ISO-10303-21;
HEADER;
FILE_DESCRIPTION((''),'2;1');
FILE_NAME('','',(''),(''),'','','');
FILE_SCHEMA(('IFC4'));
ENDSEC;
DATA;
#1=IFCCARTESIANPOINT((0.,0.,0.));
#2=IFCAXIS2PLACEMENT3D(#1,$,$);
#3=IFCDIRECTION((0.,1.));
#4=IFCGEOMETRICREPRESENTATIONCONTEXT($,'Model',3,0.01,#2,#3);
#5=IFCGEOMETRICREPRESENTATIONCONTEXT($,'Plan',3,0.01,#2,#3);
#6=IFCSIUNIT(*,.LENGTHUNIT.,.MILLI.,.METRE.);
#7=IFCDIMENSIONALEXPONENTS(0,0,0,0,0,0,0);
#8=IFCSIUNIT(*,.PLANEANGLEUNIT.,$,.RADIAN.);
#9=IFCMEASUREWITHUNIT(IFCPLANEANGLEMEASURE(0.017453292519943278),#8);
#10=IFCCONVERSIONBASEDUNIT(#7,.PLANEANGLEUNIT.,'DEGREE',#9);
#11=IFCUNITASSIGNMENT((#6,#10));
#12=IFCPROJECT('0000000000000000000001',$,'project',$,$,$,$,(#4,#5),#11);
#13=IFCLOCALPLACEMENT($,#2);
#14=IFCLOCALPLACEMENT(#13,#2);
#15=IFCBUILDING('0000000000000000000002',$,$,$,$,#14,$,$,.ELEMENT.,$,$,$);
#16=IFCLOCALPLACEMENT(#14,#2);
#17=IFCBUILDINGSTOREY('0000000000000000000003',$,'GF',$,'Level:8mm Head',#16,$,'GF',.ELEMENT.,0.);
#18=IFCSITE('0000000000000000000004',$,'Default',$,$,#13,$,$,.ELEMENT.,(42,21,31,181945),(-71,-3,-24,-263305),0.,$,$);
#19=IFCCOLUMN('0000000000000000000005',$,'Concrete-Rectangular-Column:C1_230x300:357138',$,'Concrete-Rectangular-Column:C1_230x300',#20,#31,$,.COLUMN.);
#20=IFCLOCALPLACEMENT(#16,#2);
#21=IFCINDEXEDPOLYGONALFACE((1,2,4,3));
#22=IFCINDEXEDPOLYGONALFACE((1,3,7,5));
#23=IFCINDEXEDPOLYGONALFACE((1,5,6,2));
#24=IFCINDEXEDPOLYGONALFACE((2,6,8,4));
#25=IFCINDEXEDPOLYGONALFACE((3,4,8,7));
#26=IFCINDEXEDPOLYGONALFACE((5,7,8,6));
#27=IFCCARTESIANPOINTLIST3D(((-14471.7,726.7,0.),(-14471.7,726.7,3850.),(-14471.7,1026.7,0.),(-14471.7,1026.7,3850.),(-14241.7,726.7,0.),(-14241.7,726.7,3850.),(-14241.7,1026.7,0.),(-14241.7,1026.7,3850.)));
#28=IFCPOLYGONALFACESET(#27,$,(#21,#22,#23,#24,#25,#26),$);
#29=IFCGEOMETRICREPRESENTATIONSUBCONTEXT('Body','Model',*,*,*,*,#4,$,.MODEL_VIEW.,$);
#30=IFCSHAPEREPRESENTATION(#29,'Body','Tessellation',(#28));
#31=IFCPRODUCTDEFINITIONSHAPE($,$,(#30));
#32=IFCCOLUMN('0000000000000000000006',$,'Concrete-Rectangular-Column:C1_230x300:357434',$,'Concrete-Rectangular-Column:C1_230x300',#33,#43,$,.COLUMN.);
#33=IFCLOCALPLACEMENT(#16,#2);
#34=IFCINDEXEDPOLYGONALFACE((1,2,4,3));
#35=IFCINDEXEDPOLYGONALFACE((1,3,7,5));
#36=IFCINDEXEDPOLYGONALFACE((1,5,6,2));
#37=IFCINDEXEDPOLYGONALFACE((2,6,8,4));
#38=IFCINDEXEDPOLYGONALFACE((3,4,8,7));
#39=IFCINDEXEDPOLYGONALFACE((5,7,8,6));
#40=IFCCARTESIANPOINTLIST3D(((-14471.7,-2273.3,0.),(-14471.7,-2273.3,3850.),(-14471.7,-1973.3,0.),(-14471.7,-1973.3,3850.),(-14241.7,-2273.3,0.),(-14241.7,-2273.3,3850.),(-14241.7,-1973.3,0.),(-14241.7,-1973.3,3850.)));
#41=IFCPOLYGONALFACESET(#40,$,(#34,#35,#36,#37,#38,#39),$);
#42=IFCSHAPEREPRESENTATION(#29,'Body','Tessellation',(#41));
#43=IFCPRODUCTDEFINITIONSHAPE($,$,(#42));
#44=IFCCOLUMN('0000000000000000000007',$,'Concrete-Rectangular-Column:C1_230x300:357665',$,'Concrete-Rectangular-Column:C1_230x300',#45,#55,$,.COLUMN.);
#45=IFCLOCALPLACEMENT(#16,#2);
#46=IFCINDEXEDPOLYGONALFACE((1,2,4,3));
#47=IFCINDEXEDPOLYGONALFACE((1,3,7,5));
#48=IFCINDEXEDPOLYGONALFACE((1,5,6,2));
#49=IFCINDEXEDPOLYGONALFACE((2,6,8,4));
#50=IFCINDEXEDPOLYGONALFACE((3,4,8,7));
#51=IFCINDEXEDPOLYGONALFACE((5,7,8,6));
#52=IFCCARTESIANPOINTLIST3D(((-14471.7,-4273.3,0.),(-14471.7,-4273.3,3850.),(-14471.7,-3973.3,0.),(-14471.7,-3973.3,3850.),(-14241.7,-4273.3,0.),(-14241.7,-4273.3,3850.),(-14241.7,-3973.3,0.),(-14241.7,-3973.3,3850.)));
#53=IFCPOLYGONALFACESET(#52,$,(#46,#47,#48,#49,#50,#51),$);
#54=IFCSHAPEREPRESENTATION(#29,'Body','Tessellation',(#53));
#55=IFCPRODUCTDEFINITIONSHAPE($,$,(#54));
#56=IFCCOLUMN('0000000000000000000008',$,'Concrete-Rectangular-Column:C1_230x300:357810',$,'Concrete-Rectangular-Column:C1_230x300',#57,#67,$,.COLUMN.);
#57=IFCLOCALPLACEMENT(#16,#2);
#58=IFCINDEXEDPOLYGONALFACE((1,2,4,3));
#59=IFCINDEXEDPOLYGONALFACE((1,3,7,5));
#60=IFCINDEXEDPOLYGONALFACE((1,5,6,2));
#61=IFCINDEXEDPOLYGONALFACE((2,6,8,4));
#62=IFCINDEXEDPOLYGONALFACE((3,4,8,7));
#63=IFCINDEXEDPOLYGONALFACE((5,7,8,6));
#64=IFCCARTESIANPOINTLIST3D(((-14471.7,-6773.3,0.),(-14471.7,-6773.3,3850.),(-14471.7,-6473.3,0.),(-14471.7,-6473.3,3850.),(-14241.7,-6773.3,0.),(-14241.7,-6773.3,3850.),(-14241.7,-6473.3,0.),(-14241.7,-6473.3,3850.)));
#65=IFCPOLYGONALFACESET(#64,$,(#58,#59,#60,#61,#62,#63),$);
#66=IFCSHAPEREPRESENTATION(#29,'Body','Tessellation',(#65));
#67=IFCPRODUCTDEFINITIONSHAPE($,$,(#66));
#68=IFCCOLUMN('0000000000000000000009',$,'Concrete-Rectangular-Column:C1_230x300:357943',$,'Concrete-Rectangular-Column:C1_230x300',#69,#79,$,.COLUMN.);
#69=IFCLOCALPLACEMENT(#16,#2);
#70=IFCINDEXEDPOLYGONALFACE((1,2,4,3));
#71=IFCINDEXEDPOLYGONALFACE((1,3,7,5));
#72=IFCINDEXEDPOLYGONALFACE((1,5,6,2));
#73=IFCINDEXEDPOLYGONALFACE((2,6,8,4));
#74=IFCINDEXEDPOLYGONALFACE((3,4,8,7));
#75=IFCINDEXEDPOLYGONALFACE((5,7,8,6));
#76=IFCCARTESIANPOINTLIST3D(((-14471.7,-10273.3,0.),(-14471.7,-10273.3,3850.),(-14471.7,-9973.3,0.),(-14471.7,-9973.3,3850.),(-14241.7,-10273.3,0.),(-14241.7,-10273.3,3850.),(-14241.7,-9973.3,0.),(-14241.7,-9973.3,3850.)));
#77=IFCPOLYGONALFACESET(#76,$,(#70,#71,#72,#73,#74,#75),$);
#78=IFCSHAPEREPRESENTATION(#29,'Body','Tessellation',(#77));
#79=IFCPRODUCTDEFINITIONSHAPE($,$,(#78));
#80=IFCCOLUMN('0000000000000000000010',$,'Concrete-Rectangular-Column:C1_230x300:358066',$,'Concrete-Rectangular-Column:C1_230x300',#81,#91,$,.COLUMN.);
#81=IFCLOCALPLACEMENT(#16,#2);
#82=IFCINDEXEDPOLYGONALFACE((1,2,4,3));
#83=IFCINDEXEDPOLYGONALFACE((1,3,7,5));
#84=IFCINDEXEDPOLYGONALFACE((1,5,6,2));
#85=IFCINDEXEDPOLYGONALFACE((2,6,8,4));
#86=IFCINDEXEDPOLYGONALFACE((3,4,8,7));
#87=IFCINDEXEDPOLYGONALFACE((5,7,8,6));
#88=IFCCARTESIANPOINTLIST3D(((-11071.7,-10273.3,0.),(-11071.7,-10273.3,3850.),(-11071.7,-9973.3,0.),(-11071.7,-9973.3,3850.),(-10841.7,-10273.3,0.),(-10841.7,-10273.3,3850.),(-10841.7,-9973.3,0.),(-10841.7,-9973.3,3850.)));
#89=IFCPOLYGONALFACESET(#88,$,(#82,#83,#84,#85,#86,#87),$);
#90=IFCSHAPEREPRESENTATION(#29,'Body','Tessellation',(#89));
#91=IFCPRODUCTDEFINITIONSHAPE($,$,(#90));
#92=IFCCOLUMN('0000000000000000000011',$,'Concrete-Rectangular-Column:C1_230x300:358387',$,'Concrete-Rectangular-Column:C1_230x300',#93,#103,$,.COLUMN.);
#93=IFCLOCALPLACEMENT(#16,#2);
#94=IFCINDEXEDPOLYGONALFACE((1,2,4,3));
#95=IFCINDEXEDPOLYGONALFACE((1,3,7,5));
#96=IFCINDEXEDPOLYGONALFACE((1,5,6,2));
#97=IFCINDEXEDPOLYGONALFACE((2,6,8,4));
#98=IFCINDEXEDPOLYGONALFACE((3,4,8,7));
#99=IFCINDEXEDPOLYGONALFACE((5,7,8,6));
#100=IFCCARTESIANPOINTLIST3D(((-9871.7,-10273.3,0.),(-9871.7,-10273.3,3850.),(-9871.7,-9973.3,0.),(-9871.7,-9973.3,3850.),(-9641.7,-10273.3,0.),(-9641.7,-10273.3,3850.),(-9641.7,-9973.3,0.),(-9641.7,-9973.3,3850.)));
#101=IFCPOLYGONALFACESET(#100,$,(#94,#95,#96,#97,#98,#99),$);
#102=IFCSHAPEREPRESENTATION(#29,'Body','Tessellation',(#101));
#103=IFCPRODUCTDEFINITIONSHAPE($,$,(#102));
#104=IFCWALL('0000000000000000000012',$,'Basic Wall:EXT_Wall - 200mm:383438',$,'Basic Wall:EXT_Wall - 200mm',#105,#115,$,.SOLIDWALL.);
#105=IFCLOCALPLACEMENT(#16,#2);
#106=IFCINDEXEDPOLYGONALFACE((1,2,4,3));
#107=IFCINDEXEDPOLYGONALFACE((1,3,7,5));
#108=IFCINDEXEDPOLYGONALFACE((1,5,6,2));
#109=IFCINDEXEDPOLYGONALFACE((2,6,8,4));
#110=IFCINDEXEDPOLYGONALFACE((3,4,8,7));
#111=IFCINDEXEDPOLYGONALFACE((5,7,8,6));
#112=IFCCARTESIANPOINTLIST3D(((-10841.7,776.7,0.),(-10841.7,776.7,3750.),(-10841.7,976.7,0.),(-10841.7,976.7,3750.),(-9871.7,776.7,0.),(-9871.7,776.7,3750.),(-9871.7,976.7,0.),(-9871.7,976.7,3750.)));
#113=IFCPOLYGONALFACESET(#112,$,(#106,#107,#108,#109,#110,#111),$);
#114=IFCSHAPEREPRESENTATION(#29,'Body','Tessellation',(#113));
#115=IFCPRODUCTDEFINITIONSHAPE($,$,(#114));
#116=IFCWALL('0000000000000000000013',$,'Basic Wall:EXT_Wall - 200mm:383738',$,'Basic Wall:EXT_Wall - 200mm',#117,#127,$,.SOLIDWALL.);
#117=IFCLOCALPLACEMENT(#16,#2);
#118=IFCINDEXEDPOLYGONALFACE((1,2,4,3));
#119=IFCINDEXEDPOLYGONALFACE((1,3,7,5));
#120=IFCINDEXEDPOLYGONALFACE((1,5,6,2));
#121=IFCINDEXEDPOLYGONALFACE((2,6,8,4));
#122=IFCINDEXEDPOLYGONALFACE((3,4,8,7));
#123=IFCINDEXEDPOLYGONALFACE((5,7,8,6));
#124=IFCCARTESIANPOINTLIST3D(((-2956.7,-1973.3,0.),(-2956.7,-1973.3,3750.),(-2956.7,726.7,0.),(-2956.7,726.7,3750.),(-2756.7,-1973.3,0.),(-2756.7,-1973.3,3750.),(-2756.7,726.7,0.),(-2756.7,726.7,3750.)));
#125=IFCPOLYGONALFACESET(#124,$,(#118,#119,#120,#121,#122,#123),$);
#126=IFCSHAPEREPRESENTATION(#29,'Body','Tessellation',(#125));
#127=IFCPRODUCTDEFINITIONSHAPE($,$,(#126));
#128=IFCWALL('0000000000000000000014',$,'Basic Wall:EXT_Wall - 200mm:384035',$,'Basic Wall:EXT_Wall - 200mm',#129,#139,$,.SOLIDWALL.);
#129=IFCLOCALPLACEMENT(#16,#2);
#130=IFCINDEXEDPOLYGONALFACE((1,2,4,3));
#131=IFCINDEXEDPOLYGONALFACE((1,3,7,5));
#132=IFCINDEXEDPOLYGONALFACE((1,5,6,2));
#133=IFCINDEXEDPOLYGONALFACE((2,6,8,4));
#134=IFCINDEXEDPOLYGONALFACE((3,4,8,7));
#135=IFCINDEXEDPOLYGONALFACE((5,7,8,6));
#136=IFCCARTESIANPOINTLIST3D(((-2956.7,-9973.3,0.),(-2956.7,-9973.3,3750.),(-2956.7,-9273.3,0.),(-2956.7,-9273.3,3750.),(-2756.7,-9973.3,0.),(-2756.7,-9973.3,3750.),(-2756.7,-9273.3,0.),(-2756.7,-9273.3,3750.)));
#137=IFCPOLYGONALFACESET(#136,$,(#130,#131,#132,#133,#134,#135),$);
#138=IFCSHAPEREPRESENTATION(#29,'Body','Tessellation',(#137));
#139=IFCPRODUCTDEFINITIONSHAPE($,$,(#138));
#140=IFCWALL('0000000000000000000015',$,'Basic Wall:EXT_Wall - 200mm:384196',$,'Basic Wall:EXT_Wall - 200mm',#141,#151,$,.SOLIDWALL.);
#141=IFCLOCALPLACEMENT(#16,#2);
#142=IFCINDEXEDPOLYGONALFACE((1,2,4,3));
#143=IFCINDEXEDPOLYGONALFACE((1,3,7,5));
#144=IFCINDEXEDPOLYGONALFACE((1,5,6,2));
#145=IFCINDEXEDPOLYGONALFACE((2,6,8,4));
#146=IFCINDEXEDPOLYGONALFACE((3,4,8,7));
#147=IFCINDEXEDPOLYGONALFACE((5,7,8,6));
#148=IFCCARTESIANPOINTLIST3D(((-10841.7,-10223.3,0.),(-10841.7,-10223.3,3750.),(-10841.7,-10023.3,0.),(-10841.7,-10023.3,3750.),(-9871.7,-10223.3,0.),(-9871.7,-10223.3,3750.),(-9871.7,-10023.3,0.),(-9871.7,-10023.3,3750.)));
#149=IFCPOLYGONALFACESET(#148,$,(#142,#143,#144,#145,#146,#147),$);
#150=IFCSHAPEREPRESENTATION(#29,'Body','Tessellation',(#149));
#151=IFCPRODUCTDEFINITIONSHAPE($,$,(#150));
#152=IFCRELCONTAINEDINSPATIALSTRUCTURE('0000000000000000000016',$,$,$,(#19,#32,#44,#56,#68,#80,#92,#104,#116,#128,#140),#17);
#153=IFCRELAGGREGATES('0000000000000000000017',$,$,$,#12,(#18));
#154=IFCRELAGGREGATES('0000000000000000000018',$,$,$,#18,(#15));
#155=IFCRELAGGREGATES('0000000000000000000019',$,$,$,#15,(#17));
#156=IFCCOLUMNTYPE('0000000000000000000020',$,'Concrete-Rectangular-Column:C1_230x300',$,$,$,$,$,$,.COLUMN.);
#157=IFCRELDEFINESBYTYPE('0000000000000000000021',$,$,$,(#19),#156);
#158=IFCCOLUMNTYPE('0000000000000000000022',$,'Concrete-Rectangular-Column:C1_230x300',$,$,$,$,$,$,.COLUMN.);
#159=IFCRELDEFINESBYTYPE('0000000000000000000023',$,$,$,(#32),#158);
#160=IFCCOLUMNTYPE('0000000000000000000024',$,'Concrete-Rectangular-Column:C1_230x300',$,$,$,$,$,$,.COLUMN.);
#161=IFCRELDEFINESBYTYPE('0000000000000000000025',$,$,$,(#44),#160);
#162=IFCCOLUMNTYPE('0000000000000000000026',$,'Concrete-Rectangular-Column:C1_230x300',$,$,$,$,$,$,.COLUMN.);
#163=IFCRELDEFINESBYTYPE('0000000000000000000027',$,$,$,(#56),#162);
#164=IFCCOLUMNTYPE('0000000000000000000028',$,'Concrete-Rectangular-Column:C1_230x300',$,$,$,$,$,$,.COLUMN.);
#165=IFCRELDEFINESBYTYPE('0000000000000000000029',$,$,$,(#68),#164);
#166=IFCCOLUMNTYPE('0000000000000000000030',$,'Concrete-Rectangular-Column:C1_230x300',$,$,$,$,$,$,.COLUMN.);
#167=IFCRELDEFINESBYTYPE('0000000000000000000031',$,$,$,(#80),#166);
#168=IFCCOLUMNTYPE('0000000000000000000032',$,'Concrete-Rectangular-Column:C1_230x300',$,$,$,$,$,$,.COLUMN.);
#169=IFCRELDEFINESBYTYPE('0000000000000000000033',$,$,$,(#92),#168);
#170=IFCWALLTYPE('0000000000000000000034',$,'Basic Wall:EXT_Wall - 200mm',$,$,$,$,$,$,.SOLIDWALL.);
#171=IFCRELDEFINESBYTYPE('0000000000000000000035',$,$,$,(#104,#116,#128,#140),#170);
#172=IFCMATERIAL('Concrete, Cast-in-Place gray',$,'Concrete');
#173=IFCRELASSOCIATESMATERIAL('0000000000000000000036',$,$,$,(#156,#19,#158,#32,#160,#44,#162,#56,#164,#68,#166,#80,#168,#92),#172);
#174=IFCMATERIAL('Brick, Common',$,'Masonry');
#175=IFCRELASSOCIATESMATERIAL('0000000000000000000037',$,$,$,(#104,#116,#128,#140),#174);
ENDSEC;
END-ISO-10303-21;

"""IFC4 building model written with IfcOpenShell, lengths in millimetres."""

from ifc_helpers import new_model, entity, si_unit, converted_unit, direction, frame, origin, place, context, subcontext, project, spatial, indexed_curve, outline, extrude, source, transform, mapped, material, type_object, type_shapes, element, save


model = new_model("IFC4")

# Units and contexts
model_context = context("Model", 3, precision=0.01, world=origin(), true_north=direction((0.0, 1.0)))
plan_context = context("Plan", 3, precision=0.01, world=origin(), true_north=direction((0.0, 1.0)))
body_context = subcontext(model_context, "Body", "Model", "MODEL_VIEW")
ifc_project = project(units=[si_unit("LENGTHUNIT", "METRE", prefix="MILLI"), converted_unit("PLANEANGLEUNIT", "DEGREE", entity("IfcPlaneAngleMeasure", 0.017453292519943278), si_unit("PLANEANGLEUNIT", "RADIAN"), dimensions=[0, 0, 0, 0, 0, 0, 0])], contexts=[model_context, plan_context])

# Site, building, storey
site_placement = place(None, origin())
site = spatial("IfcSite", under=ifc_project, at=site_placement, Name="Default", CompositionType="ELEMENT", RefLatitude=(42, 21, 31, 181945), RefLongitude=(-71, -3, -24, -263305), RefElevation=0.0)
building_placement = place(site_placement, origin())
building = spatial("IfcBuilding", under=site, at=building_placement, CompositionType="ELEMENT")
storey_placement = place(building_placement, origin())
storey = spatial("IfcBuildingStorey", under=building, at=storey_placement, Name="GF", ObjectType="Level:8mm Head", LongName="GF", CompositionType="ELEMENT", Elevation=0.0)

# Columns
ifc_material_1 = material(Name="Concrete, Cast-in-Place gray", Category="Concrete")
column_type_1 = type_object("IfcColumnType", Name="Concrete-Rectangular-Column:C1_230x300", PredefinedType="COLUMN", material=ifc_material_1)
shared_shape_1 = source(origin(), body_context, "Body", "SweptSolid", [
    extrude(outline(indexed_curve([(-1925.0, -150.0), (1925.0, -150.0), (1925.0, 150.0), (-1925.0, 150.0), (-1925.0, -150.0)], self_intersect=False)), frame((-14471.7, 876.7, 1925.0), z_axis=(1.0, 0.0, 0.0), x_axis=(0.0, 0.0, 1.0)), (0.0, 0.0, 1.0), 230.0),
])
type_shapes(column_type_1, [shared_shape_1])
column_1_placement = place(storey_placement, origin())
element("IfcColumn", 1, at=column_1_placement, inside=storey, type_object=column_type_1, material=ifc_material_1, Name="Concrete-Rectangular-Column:C1_230x300:357138", ObjectType="Concrete-Rectangular-Column:C1_230x300", PredefinedType="COLUMN", context=body_context, shape_type="MappedRepresentation", body=[
    mapped(shared_shape_1, transform((0.0, 0.0, 0.0), scale=1.0)),
])
column_type_2 = type_object("IfcColumnType", Name="Concrete-Rectangular-Column:C1_230x300", PredefinedType="COLUMN", material=ifc_material_1)
shared_shape_2 = source(origin(), body_context, "Body", "SweptSolid", [
    extrude(outline(indexed_curve([(-1925.0, -150.0), (1925.0, -150.0), (1925.0, 150.0), (-1925.0, 150.0), (-1925.0, -150.0)], self_intersect=False)), frame((-14471.7, -2123.3, 1925.0), z_axis=(1.0, 0.0, 0.0), x_axis=(0.0, 0.0, 1.0)), (0.0, 0.0, 1.0), 230.0),
])
type_shapes(column_type_2, [shared_shape_2])
column_2_placement = place(storey_placement, origin())
element("IfcColumn", 2, at=column_2_placement, inside=storey, type_object=column_type_2, material=ifc_material_1, Name="Concrete-Rectangular-Column:C1_230x300:357434", ObjectType="Concrete-Rectangular-Column:C1_230x300", PredefinedType="COLUMN", context=body_context, shape_type="MappedRepresentation", body=[
    mapped(shared_shape_2, transform((0.0, 0.0, 0.0), scale=1.0)),
])
column_type_3 = type_object("IfcColumnType", Name="Concrete-Rectangular-Column:C1_230x300", PredefinedType="COLUMN", material=ifc_material_1)
shared_shape_3 = source(origin(), body_context, "Body", "SweptSolid", [
    extrude(outline(indexed_curve([(-1925.0, -150.0), (1925.0, -150.0), (1925.0, 150.0), (-1925.0, 150.0), (-1925.0, -150.0)], self_intersect=False)), frame((-14471.7, -4123.3, 1925.0), z_axis=(1.0, 0.0, 0.0), x_axis=(0.0, 0.0, 1.0)), (0.0, 0.0, 1.0), 230.0),
])
type_shapes(column_type_3, [shared_shape_3])
column_3_placement = place(storey_placement, origin())
element("IfcColumn", 3, at=column_3_placement, inside=storey, type_object=column_type_3, material=ifc_material_1, Name="Concrete-Rectangular-Column:C1_230x300:357665", ObjectType="Concrete-Rectangular-Column:C1_230x300", PredefinedType="COLUMN", context=body_context, shape_type="MappedRepresentation", body=[
    mapped(shared_shape_3, transform((0.0, 0.0, 0.0), scale=1.0)),
])
column_type_4 = type_object("IfcColumnType", Name="Concrete-Rectangular-Column:C1_230x300", PredefinedType="COLUMN", material=ifc_material_1)
shared_shape_4 = source(origin(), body_context, "Body", "SweptSolid", [
    extrude(outline(indexed_curve([(-1925.0, -150.0), (1925.0, -150.0), (1925.0, 150.0), (-1925.0, 150.0), (-1925.0, -150.0)], self_intersect=False)), frame((-14471.7, -6623.3, 1925.0), z_axis=(1.0, 0.0, 0.0), x_axis=(0.0, 0.0, 1.0)), (0.0, 0.0, 1.0), 230.0),
])
type_shapes(column_type_4, [shared_shape_4])
column_4_placement = place(storey_placement, origin())
element("IfcColumn", 4, at=column_4_placement, inside=storey, type_object=column_type_4, material=ifc_material_1, Name="Concrete-Rectangular-Column:C1_230x300:357810", ObjectType="Concrete-Rectangular-Column:C1_230x300", PredefinedType="COLUMN", context=body_context, shape_type="MappedRepresentation", body=[
    mapped(shared_shape_4, transform((0.0, 0.0, 0.0), scale=1.0)),
])
column_type_5 = type_object("IfcColumnType", Name="Concrete-Rectangular-Column:C1_230x300", PredefinedType="COLUMN", material=ifc_material_1)
shared_shape_5 = source(origin(), body_context, "Body", "SweptSolid", [
    extrude(outline(indexed_curve([(-1925.0, -150.0), (1925.0, -150.0), (1925.0, 150.0), (-1925.0, 150.0), (-1925.0, -150.0)], self_intersect=False)), frame((-14471.7, -10123.3, 1925.0), z_axis=(1.0, 0.0, 0.0), x_axis=(0.0, 0.0, 1.0)), (0.0, 0.0, 1.0), 230.0),
])
type_shapes(column_type_5, [shared_shape_5])
column_5_placement = place(storey_placement, origin())
element("IfcColumn", 5, at=column_5_placement, inside=storey, type_object=column_type_5, material=ifc_material_1, Name="Concrete-Rectangular-Column:C1_230x300:357943", ObjectType="Concrete-Rectangular-Column:C1_230x300", PredefinedType="COLUMN", context=body_context, shape_type="MappedRepresentation", body=[
    mapped(shared_shape_5, transform((0.0, 0.0, 0.0), scale=1.0)),
])
column_type_6 = type_object("IfcColumnType", Name="Concrete-Rectangular-Column:C1_230x300", PredefinedType="COLUMN", material=ifc_material_1)
shared_shape_6 = source(origin(), body_context, "Body", "SweptSolid", [
    extrude(outline(indexed_curve([(-1925.0, -150.0), (1925.0, -150.0), (1925.0, 150.0), (-1925.0, 150.0), (-1925.0, -150.0)], self_intersect=False)), frame((-11071.7, -10123.3, 1925.0), z_axis=(1.0, 0.0, 0.0), x_axis=(0.0, 0.0, 1.0)), (0.0, 0.0, 1.0), 230.0),
])
type_shapes(column_type_6, [shared_shape_6])
column_6_placement = place(storey_placement, origin())
element("IfcColumn", 6, at=column_6_placement, inside=storey, type_object=column_type_6, material=ifc_material_1, Name="Concrete-Rectangular-Column:C1_230x300:358066", ObjectType="Concrete-Rectangular-Column:C1_230x300", PredefinedType="COLUMN", context=body_context, shape_type="MappedRepresentation", body=[
    mapped(shared_shape_6, transform((0.0, 0.0, 0.0), scale=1.0)),
])
column_type_7 = type_object("IfcColumnType", Name="Concrete-Rectangular-Column:C1_230x300", PredefinedType="COLUMN", material=ifc_material_1)
shared_shape_7 = source(origin(), body_context, "Body", "SweptSolid", [
    extrude(outline(indexed_curve([(-1925.0, -150.0), (1925.0, -150.0), (1925.0, 150.0), (-1925.0, 150.0), (-1925.0, -150.0)], self_intersect=False)), frame((-9871.7, -10123.3, 1925.0), z_axis=(1.0, 0.0, 0.0), x_axis=(0.0, 0.0, 1.0)), (0.0, 0.0, 1.0), 230.0),
])
type_shapes(column_type_7, [shared_shape_7])
column_7_placement = place(storey_placement, origin())
element("IfcColumn", 7, at=column_7_placement, inside=storey, type_object=column_type_7, material=ifc_material_1, Name="Concrete-Rectangular-Column:C1_230x300:358387", ObjectType="Concrete-Rectangular-Column:C1_230x300", PredefinedType="COLUMN", context=body_context, shape_type="MappedRepresentation", body=[
    mapped(shared_shape_7, transform((0.0, 0.0, 0.0), scale=1.0)),
])

# Walls
ifc_material_2 = material(Name="Brick, Common", Category="Masonry")
wall_type_1 = type_object("IfcWallType", Name="Basic Wall:EXT_Wall - 200mm", PredefinedType="SOLIDWALL")
wall_1_placement = place(storey_placement, frame((-10841.7, 876.7, 0.0)))
element("IfcWall", 8, at=wall_1_placement, inside=storey, type_object=wall_type_1, material=ifc_material_2, Name="Basic Wall:EXT_Wall - 200mm:383438", ObjectType="Basic Wall:EXT_Wall - 200mm", PredefinedType="SOLIDWALL", context=body_context, shape_type="SweptSolid", body=[
    extrude(outline(indexed_curve([(970.0, 100.0), (0.0, 100.0), (0.0, -100.0), (970.0, -100.0), (970.0, 100.0)], self_intersect=False)), origin(), (0.0, 0.0, 1.0), 3750.0),
])
wall_2_placement = place(storey_placement, frame((-2856.7, 726.7, 0.0), z_axis=(0.0, 0.0, 1.0), x_axis=(0.0, -1.0, 0.0)))
element("IfcWall", 9, at=wall_2_placement, inside=storey, type_object=wall_type_1, material=ifc_material_2, Name="Basic Wall:EXT_Wall - 200mm:383738", ObjectType="Basic Wall:EXT_Wall - 200mm", PredefinedType="SOLIDWALL", context=body_context, shape_type="SweptSolid", body=[
    extrude(outline(indexed_curve([(2700.0, 100.0), (0.0, 100.0), (0.0, -100.0), (2700.0, -100.0), (2700.0, 100.0)], self_intersect=False)), origin(), (0.0, 0.0, 1.0), 3750.0),
])
wall_3_placement = place(storey_placement, frame((-2856.7, -9273.3, 0.0), z_axis=(0.0, 0.0, 1.0), x_axis=(0.0, -1.0, 0.0)))
element("IfcWall", 10, at=wall_3_placement, inside=storey, type_object=wall_type_1, material=ifc_material_2, Name="Basic Wall:EXT_Wall - 200mm:384035", ObjectType="Basic Wall:EXT_Wall - 200mm", PredefinedType="SOLIDWALL", context=body_context, shape_type="SweptSolid", body=[
    extrude(outline(indexed_curve([(700.0, 100.0), (0.0, 100.0), (0.0, -100.0), (700.0, -100.0), (700.0, 100.0)], self_intersect=False)), origin(), (0.0, 0.0, 1.0), 3750.0),
])
wall_4_placement = place(storey_placement, frame((-9871.7, -10123.3, 0.0), z_axis=(0.0, 0.0, 1.0), x_axis=(-1.0, 0.0, 0.0)))
element("IfcWall", 11, at=wall_4_placement, inside=storey, type_object=wall_type_1, material=ifc_material_2, Name="Basic Wall:EXT_Wall - 200mm:384196", ObjectType="Basic Wall:EXT_Wall - 200mm", PredefinedType="SOLIDWALL", context=body_context, shape_type="SweptSolid", body=[
    extrude(outline(indexed_curve([(970.0, 100.0), (0.0, 100.0), (0.0, -100.0), (970.0, -100.0), (970.0, 100.0)], self_intersect=False)), origin(), (0.0, 0.0, 1.0), 3750.0),
])

save(model, "model.ifc")
